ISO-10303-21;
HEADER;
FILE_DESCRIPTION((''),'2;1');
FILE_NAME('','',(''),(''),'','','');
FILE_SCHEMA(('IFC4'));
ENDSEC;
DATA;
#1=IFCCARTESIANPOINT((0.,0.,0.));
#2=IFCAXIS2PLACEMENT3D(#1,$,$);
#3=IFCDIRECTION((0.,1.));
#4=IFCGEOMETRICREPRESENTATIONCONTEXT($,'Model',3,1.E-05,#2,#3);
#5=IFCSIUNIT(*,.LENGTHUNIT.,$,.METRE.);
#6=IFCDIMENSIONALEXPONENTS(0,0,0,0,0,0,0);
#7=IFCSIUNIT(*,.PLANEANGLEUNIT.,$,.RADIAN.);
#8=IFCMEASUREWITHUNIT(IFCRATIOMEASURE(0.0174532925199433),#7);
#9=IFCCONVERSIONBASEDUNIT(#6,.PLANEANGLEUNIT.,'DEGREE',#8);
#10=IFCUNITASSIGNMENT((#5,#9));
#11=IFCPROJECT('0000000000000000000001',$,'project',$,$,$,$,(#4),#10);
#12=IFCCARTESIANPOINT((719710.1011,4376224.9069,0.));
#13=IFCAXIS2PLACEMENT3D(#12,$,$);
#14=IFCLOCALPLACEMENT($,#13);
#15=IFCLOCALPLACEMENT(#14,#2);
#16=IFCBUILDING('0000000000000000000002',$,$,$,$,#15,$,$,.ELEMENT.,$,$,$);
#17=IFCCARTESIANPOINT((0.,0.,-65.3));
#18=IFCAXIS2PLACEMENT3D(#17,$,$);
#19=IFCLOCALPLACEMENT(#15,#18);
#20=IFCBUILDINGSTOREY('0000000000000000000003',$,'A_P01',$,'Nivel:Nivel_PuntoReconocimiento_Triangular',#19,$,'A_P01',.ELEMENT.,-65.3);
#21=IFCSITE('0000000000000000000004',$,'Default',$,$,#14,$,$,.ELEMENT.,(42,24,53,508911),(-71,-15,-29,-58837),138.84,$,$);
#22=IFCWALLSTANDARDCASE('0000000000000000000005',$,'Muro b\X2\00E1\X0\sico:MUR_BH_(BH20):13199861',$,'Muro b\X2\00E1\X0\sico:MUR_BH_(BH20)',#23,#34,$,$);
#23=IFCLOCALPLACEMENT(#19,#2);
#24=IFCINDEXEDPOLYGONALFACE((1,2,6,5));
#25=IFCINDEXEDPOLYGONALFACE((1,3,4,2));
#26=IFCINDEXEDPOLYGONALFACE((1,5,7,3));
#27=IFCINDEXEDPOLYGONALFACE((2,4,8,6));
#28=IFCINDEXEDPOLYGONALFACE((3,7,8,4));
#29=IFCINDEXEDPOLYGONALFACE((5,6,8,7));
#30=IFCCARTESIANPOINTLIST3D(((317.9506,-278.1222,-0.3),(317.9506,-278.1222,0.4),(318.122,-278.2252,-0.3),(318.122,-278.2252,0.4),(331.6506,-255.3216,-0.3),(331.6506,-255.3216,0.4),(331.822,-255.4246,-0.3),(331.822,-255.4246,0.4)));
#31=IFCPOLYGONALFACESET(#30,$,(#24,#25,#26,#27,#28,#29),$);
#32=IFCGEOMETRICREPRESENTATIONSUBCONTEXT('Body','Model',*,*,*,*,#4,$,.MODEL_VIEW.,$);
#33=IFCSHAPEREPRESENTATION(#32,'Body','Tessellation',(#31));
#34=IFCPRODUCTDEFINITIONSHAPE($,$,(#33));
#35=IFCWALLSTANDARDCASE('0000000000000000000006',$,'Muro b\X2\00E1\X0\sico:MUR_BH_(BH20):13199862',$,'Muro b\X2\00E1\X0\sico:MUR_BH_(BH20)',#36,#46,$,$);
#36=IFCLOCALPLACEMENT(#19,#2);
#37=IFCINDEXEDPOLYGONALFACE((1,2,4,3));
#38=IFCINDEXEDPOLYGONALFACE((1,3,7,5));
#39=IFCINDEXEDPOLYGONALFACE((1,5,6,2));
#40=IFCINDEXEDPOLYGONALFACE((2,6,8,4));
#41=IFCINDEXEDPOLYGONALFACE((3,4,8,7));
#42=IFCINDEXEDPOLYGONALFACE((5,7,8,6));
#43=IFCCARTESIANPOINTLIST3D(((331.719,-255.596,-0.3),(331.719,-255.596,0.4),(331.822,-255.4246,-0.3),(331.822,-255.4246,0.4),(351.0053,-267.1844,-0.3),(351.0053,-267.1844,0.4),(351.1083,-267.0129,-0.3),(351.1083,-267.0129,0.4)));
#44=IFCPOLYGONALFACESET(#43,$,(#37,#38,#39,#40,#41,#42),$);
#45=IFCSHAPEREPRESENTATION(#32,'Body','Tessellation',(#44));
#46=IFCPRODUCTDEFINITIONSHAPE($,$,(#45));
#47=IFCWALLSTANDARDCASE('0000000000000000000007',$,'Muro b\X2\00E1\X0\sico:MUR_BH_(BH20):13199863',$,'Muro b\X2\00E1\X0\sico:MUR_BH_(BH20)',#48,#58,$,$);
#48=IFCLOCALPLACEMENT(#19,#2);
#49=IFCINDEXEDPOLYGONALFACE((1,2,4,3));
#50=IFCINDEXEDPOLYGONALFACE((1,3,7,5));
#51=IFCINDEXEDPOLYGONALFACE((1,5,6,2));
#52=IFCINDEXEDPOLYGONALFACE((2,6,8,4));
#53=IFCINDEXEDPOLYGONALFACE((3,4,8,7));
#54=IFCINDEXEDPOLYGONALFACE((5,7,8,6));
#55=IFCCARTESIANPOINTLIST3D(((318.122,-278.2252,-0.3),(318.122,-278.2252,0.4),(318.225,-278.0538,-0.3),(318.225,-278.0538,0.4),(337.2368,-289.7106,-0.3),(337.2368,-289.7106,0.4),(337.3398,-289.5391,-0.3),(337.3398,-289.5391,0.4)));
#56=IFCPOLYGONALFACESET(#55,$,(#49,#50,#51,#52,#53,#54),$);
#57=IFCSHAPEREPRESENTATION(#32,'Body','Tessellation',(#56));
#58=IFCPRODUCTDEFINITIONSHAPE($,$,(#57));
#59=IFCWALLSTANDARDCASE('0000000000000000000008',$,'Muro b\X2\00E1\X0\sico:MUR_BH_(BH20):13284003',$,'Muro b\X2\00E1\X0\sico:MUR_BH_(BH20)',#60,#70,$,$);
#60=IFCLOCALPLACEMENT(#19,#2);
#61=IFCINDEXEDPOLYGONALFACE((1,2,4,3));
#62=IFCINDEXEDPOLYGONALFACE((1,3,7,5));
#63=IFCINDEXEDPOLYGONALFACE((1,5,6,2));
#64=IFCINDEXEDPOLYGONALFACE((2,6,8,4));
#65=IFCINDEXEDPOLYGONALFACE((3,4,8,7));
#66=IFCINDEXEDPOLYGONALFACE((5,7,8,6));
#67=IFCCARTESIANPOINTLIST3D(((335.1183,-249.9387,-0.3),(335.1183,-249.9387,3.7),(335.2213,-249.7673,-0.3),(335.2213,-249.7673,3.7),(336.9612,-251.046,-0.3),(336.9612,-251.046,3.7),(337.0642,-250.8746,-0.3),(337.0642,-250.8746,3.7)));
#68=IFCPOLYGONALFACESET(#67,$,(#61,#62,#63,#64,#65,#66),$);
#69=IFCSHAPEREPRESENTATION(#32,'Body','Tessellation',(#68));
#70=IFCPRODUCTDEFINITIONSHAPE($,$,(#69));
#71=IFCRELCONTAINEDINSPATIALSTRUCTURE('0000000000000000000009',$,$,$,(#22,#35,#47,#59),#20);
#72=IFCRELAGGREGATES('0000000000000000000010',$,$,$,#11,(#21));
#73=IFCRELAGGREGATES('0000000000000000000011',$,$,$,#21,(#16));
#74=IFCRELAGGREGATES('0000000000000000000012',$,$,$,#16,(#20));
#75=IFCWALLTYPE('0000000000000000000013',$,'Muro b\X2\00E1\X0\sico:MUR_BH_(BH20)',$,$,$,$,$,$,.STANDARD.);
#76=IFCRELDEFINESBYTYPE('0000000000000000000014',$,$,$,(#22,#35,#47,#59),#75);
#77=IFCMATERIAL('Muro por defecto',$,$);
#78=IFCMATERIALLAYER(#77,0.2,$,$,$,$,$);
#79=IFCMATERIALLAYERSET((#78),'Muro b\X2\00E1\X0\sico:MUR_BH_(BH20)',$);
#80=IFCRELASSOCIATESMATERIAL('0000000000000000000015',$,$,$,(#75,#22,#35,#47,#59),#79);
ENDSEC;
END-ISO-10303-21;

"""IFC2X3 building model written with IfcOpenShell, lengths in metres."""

from ifc_helpers import new_model, entity, si_unit, converted_unit, direction, frame, frame_2d, origin, place, context, subcontext, project, spatial, rectangle, extrude, material, layer, layer_set, layer_usage, type_object, element, save


model = new_model("IFC2X3")

# Units and contexts
model_context = context("Model", 3, precision=1e-05, world=origin(), true_north=direction((0.0, 1.0)))
body_context = subcontext(model_context, "Body", "Model", "MODEL_VIEW")
ifc_project = project(units=[si_unit("LENGTHUNIT", "METRE"), converted_unit("PLANEANGLEUNIT", "DEGREE", entity("IfcRatioMeasure", 0.0174532925199433), si_unit("PLANEANGLEUNIT", "RADIAN"), dimensions=[0, 0, 0, 0, 0, 0, 0])], contexts=[model_context])

# Site, building, storey
site_placement = place(None, frame((719710.1011, 4376224.9069, 0.0)))
site = spatial("IfcSite", under=ifc_project, at=site_placement, Name="Default", CompositionType="ELEMENT", RefLatitude=(42, 24, 53, 508911), RefLongitude=(-71, -15, -29, -58837), RefElevation=138.84)
building_placement = place(site_placement, origin())
building = spatial("IfcBuilding", under=site, at=building_placement, CompositionType="ELEMENT")
storey_placement = place(building_placement, frame((0.0, 0.0, -65.3)))
storey = spatial("IfcBuildingStorey", under=building, at=storey_placement, Name="A_P01", ObjectType="Nivel:Nivel_PuntoReconocimiento_Triangular", LongName="A_P01", CompositionType="ELEMENT", Elevation=-65.3)

# Shared definitions
ifc_material_1 = material(Name="Muro por defecto")
ifc_layer_1 = layer(ifc_material_1, 0.2)
ifc_layer_set_1 = layer_set([ifc_layer_1], Name="Muro básico:MUR_BH_(BH20)")
wall_type = type_object("IfcWallType", Name="Muro básico:MUR_BH_(BH20)", PredefinedType="STANDARD", material=ifc_layer_set_1)

# Walls
ifc_layer_usage_1 = layer_usage(ifc_layer_set_1, "AXIS2", "NEGATIVE", 0.1)
wall_1_placement = place(storey_placement, frame((318.0363, -278.1737, -0.3), z_axis=(0.0, 0.0, 1.0), x_axis=(0.515038, 0.857167, 0.0)))
element("IfcWallStandardCase", 1, at=wall_1_placement, inside=storey, type_object=wall_type, material=ifc_layer_usage_1, Name="Muro básico:MUR_BH_(BH20):13199861", ObjectType="Muro básico:MUR_BH_(BH20)", context=body_context, shape_type="SweptSolid", body=[
    extrude(rectangle(XDim=26.6, YDim=0.2, at=frame_2d((13.3, 0.0), x_axis=(-1.0, 0.0))), origin(), (0.0, 0.0, 1.0), 0.7),
])
ifc_layer_usage_2 = layer_usage(ifc_layer_set_1, "AXIS2", "NEGATIVE", 0.1)
wall_2_placement = place(storey_placement, frame((331.7705, -255.5103, -0.3), z_axis=(0.0, 0.0, 1.0), x_axis=(0.857167, -0.515038, 0.0)))
element("IfcWallStandardCase", 2, at=wall_2_placement, inside=storey, type_object=wall_type, material=ifc_layer_usage_2, Name="Muro básico:MUR_BH_(BH20):13199862", ObjectType="Muro básico:MUR_BH_(BH20)", context=body_context, shape_type="SweptSolid", body=[
    extrude(rectangle(XDim=22.5, YDim=0.2, at=frame_2d((11.25, 0.0), x_axis=(-1.0, 0.0))), origin(), (0.0, 0.0, 1.0), 0.7),
])
ifc_layer_usage_3 = layer_usage(ifc_layer_set_1, "AXIS2", "NEGATIVE", 0.1)
wall_3_placement = place(storey_placement, frame((337.2883, -289.6249, -0.3), z_axis=(0.0, 0.0, 1.0), x_axis=(-0.857167, 0.515038, 0.0)))
element("IfcWallStandardCase", 3, at=wall_3_placement, inside=storey, type_object=wall_type, material=ifc_layer_usage_3, Name="Muro básico:MUR_BH_(BH20):13199863", ObjectType="Muro básico:MUR_BH_(BH20)", context=body_context, shape_type="SweptSolid", body=[
    extrude(rectangle(XDim=22.3, YDim=0.2, at=frame_2d((11.15, 0.0), x_axis=(-1.0, 0.0))), origin(), (0.0, 0.0, 1.0), 0.7),
])
ifc_layer_usage_4 = layer_usage(ifc_layer_set_1, "AXIS2", "NEGATIVE", 0.1)
wall_4_placement = place(storey_placement, frame((337.0127, -250.9603, -0.3), z_axis=(0.0, 0.0, 1.0), x_axis=(-0.857167, 0.515038, 0.0)))
element("IfcWallStandardCase", 4, at=wall_4_placement, inside=storey, type_object=wall_type, material=ifc_layer_usage_4, Name="Muro básico:MUR_BH_(BH20):13284003", ObjectType="Muro básico:MUR_BH_(BH20)", context=body_context, shape_type="SweptSolid", body=[
    extrude(rectangle(XDim=2.15, YDim=0.2, at=frame_2d((1.075, 0.0), x_axis=(-1.0, 0.0))), origin(), (0.0, 0.0, 1.0), 4.0),
])

save(model, "model.ifc")
